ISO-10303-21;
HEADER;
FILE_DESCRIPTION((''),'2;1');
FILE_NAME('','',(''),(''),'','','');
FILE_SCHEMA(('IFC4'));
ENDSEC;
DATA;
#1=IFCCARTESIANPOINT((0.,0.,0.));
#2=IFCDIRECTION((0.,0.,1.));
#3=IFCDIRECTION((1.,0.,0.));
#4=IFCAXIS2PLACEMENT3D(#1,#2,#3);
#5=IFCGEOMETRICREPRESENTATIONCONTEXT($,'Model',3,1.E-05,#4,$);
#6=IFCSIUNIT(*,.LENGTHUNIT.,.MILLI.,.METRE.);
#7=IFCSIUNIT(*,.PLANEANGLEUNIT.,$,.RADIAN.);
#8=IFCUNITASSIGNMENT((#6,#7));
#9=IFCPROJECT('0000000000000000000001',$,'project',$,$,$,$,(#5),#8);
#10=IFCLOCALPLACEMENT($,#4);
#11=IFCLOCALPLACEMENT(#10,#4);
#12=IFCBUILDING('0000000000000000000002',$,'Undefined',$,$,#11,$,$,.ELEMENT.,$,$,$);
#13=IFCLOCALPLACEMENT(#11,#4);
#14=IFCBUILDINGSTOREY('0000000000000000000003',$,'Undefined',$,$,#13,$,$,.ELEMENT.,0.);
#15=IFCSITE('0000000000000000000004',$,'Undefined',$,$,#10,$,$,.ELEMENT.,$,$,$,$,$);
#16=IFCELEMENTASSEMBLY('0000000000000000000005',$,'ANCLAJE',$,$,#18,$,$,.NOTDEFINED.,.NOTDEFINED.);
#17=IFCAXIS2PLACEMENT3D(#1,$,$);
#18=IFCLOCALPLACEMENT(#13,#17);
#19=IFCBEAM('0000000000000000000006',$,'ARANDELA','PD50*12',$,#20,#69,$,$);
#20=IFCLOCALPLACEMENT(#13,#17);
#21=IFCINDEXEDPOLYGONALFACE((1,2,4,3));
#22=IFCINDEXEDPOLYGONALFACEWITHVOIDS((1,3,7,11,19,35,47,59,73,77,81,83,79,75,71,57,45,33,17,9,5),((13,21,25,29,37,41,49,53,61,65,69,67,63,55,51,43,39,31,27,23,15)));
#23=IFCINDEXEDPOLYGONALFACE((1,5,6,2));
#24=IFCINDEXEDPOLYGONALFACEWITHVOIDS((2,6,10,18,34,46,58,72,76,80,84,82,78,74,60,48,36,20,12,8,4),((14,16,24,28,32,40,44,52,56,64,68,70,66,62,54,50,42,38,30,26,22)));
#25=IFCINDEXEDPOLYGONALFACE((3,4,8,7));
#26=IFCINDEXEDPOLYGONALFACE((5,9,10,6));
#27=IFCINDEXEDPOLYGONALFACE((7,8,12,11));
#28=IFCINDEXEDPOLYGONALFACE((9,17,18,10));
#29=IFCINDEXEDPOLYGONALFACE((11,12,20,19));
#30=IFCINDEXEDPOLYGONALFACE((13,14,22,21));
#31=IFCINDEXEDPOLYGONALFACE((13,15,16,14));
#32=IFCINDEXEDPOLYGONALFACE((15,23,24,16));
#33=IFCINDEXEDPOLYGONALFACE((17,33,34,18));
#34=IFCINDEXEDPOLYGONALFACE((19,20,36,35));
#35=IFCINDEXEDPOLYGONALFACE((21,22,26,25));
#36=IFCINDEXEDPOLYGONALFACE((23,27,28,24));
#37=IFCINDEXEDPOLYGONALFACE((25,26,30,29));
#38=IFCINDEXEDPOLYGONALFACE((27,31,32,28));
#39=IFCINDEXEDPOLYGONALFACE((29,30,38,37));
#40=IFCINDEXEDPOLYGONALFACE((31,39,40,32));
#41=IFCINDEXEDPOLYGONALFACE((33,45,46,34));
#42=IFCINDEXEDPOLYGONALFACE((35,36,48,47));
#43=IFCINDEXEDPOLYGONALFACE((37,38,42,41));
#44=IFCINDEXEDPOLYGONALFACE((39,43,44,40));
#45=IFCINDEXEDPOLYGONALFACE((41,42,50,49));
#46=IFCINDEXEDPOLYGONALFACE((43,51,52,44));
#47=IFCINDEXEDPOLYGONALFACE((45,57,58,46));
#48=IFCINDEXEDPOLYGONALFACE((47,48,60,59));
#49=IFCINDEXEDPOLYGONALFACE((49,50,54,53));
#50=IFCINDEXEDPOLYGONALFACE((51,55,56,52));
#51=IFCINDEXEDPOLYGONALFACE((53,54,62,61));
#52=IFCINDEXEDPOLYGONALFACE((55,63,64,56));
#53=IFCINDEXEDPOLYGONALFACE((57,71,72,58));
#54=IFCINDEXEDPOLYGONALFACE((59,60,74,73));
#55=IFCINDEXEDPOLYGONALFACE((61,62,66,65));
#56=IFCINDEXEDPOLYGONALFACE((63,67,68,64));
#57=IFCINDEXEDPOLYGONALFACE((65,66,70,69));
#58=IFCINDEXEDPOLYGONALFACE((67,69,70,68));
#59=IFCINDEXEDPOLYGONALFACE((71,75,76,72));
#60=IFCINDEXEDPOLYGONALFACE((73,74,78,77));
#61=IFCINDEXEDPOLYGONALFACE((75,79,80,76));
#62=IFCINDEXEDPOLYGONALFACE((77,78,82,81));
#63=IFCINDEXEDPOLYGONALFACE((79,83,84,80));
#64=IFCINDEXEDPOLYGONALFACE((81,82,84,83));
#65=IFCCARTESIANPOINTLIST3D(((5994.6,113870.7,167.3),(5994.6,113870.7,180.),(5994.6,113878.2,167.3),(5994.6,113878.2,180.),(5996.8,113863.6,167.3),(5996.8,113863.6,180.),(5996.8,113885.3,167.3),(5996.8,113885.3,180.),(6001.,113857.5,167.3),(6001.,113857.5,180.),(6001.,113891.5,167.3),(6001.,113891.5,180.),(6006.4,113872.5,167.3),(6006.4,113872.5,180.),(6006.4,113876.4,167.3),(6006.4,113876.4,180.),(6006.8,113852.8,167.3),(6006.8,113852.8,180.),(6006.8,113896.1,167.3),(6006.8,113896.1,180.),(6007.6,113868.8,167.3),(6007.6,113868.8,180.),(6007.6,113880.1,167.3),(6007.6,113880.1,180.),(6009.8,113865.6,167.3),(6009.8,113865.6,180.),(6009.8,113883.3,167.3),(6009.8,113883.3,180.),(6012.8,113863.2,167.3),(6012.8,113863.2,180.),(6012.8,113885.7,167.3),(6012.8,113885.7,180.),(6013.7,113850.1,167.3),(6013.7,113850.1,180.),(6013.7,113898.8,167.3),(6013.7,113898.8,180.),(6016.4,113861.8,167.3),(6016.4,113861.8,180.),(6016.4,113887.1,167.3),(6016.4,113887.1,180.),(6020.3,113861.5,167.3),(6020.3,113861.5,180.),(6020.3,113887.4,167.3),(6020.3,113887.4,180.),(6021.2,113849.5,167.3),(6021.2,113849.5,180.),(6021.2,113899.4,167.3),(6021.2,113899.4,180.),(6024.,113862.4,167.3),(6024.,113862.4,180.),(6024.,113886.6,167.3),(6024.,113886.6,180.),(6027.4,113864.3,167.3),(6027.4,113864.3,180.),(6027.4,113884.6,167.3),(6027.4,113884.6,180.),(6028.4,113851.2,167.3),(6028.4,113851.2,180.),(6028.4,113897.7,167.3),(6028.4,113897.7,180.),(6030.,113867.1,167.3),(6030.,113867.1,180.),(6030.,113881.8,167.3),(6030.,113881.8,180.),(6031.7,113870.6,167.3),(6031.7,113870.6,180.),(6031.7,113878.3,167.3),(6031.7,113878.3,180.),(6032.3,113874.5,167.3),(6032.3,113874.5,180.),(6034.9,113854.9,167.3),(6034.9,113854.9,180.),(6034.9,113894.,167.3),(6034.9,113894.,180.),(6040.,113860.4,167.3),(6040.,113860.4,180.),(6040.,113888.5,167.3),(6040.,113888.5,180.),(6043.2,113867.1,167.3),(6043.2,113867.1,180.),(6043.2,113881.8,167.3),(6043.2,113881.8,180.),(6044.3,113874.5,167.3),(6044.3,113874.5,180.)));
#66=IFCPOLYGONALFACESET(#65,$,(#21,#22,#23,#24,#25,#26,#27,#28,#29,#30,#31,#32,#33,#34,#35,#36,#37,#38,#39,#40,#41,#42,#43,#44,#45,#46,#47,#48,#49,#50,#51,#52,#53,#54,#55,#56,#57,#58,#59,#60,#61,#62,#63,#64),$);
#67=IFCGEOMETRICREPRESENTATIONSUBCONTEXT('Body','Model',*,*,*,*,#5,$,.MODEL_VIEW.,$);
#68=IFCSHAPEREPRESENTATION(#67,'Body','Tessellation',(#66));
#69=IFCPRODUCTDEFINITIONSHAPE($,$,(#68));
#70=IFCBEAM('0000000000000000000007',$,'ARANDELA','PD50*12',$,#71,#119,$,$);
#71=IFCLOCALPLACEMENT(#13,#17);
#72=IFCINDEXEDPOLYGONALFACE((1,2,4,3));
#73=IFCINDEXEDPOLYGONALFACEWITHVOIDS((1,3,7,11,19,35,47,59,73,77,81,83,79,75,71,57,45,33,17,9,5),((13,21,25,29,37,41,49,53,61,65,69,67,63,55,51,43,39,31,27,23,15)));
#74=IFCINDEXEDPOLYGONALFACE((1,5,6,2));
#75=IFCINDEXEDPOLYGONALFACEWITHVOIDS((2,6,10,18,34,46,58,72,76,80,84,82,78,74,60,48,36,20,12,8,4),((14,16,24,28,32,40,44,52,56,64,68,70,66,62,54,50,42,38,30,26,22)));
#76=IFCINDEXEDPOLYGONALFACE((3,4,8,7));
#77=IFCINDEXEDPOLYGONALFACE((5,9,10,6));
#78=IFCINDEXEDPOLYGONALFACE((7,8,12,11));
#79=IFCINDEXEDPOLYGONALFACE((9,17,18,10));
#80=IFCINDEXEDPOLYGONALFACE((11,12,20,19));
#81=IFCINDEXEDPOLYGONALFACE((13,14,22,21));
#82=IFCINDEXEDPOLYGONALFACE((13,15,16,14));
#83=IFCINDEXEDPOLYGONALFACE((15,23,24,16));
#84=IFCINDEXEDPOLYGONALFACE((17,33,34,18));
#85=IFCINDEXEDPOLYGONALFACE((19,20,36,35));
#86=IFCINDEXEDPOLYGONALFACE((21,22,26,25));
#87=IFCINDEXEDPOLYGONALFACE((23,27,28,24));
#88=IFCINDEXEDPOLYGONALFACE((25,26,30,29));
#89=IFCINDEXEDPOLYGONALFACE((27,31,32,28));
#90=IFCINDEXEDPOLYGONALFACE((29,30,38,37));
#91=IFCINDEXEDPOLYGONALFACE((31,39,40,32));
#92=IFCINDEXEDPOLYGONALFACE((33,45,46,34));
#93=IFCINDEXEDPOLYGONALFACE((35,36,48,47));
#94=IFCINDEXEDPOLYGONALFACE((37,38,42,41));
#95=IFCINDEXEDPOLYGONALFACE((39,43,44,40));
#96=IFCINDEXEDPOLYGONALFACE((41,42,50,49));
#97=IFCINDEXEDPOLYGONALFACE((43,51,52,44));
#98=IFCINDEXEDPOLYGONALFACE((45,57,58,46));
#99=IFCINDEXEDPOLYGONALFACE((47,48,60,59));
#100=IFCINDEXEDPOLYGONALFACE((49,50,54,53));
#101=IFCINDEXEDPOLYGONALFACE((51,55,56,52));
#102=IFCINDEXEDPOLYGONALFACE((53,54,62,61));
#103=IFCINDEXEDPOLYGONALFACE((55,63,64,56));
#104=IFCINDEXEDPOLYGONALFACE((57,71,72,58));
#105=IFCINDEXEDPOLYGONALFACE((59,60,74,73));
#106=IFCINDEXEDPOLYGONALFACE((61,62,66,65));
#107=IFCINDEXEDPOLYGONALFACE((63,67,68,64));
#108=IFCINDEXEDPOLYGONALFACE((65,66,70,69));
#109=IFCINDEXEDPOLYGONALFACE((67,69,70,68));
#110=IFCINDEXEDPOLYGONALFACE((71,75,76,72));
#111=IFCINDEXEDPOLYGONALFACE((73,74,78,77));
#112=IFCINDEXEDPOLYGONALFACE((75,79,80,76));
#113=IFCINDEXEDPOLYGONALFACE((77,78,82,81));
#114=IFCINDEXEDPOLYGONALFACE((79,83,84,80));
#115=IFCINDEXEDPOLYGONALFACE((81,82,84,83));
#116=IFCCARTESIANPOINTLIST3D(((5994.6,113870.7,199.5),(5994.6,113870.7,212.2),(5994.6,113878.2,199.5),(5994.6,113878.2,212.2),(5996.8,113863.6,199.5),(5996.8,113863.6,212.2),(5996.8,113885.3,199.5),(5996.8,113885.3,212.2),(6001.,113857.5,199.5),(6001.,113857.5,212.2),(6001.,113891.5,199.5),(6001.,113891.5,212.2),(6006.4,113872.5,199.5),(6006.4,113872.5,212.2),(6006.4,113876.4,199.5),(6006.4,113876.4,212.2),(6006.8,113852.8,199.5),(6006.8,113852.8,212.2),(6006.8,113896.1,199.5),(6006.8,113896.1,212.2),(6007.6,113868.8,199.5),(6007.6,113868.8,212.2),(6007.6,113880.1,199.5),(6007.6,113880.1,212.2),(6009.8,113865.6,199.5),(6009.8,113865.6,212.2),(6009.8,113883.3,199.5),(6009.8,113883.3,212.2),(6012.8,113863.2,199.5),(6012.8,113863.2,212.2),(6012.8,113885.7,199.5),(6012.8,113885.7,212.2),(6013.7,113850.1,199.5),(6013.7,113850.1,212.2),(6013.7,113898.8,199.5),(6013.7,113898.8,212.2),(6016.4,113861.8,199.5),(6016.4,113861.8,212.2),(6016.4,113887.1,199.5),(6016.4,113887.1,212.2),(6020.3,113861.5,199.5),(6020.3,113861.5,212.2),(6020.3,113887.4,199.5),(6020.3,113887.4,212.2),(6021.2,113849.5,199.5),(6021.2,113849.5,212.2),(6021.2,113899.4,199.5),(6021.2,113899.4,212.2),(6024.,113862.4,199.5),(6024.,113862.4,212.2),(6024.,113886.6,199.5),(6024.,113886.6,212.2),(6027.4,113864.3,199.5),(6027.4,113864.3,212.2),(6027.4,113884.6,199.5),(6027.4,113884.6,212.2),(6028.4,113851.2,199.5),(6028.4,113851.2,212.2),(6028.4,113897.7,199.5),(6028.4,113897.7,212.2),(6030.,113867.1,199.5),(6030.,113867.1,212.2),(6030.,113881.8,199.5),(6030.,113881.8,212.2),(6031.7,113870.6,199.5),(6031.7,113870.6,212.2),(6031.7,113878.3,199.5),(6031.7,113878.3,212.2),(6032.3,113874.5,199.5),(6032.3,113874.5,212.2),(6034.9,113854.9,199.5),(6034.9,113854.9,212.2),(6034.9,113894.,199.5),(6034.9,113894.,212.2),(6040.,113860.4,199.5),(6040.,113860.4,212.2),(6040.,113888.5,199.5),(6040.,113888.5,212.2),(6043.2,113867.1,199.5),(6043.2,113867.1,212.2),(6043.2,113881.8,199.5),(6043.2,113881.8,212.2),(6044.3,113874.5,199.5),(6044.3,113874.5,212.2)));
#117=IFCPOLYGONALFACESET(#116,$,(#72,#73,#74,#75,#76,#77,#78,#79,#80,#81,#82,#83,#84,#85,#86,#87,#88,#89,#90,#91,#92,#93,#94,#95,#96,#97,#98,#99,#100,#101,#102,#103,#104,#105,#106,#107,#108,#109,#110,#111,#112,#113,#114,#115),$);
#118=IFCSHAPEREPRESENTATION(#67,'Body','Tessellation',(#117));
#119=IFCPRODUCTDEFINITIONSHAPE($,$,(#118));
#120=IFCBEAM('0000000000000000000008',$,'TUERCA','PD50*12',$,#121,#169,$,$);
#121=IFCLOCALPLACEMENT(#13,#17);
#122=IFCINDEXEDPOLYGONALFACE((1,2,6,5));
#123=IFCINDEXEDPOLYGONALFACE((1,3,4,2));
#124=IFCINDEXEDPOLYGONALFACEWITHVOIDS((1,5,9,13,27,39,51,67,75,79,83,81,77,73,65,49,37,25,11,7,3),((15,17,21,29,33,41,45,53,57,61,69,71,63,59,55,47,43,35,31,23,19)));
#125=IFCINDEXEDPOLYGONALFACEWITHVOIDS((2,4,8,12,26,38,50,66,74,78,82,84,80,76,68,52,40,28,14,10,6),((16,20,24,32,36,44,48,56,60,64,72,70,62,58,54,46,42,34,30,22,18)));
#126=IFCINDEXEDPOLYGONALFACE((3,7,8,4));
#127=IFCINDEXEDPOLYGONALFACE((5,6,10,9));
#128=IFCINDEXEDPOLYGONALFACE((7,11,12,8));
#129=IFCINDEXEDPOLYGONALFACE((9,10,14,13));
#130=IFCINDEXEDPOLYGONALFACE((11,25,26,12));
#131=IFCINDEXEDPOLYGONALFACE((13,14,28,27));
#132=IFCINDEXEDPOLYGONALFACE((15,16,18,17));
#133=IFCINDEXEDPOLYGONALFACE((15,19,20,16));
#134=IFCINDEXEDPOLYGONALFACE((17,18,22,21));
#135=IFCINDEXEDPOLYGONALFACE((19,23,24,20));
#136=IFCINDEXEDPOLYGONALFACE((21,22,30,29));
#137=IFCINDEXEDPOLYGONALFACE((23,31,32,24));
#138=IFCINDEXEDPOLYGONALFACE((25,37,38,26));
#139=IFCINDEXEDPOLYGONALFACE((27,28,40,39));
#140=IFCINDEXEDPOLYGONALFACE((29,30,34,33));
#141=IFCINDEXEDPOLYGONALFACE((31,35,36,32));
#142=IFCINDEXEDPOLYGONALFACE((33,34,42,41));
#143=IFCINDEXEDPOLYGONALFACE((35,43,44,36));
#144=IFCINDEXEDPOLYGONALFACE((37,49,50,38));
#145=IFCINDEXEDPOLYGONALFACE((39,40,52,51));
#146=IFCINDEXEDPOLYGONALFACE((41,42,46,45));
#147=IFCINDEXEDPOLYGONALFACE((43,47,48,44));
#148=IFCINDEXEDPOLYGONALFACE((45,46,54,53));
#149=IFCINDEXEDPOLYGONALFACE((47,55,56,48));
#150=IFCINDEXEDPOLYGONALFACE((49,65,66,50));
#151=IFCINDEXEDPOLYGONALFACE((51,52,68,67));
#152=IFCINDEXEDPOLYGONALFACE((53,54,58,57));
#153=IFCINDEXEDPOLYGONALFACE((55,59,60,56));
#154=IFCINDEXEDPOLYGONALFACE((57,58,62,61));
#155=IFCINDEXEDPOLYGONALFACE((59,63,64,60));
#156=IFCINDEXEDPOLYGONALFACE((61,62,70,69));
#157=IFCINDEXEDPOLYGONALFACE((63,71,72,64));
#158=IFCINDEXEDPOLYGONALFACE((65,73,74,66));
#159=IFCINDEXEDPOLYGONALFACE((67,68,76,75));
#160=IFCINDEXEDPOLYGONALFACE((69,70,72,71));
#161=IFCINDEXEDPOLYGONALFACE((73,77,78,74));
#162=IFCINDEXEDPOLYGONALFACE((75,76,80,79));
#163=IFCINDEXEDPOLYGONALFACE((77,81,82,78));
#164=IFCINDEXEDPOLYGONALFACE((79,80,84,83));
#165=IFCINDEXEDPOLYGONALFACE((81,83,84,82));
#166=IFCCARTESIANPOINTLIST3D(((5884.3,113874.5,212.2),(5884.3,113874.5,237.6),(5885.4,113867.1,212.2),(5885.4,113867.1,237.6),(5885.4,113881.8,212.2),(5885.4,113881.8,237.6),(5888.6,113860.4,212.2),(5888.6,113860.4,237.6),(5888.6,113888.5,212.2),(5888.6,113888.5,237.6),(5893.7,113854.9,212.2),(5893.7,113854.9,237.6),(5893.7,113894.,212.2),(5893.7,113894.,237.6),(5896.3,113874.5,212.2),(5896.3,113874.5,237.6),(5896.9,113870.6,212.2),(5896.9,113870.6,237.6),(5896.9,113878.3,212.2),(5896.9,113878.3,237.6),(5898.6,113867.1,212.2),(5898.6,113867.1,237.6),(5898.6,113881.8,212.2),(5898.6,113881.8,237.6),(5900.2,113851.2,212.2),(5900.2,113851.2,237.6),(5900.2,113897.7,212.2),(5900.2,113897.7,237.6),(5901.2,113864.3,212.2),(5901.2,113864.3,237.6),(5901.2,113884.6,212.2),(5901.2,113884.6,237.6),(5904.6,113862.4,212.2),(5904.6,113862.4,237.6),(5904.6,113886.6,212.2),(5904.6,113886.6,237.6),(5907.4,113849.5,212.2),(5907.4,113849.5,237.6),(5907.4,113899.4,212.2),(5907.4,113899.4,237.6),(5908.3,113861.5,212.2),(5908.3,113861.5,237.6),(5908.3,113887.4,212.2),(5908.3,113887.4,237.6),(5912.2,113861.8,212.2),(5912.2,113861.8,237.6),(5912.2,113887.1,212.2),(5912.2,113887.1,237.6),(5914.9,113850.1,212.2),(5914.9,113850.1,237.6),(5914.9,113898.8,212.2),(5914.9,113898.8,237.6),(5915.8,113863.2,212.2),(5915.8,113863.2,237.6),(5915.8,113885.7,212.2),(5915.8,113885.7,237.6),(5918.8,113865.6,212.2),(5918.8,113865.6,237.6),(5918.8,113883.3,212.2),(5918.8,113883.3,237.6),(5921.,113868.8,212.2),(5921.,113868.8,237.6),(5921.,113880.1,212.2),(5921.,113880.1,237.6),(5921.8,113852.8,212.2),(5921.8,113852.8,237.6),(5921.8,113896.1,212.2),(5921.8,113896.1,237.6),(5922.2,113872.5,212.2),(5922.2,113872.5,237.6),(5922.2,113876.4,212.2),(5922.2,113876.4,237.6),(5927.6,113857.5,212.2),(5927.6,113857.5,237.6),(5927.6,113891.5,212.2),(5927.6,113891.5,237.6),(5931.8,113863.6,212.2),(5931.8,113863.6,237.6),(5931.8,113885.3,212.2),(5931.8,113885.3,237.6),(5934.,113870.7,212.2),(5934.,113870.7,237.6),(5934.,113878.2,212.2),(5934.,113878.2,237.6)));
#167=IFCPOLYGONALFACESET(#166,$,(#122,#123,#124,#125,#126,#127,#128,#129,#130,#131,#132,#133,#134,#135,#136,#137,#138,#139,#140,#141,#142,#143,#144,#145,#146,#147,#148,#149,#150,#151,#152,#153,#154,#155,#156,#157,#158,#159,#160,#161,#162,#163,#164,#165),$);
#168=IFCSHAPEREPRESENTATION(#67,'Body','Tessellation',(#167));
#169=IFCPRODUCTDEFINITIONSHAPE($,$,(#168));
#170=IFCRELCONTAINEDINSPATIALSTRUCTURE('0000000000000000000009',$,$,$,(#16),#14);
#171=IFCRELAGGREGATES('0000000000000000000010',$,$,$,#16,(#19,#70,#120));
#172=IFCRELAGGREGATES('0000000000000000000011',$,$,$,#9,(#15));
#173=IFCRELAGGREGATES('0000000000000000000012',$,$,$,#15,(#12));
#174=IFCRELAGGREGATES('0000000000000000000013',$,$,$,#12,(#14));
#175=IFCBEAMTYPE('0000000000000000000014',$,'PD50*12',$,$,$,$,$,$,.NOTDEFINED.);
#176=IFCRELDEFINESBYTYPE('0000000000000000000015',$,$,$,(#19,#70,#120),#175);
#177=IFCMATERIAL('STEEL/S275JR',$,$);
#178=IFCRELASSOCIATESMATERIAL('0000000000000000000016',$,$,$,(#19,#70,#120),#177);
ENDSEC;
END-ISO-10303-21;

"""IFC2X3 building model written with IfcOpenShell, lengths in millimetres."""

from ifc_helpers import new_model, si_unit, frame, origin_with_axes, origin_2d_with_axis, place, context, subcontext, project, spatial, hollow_circle, extrude, material, type_object, element, aggregate, save


model = new_model("IFC2X3")

# Units and contexts
model_context = context("Model", 3, precision=1e-05, world=origin_with_axes())
body_context = subcontext(model_context, "Body", "Model", "MODEL_VIEW")
ifc_project = project(units=[si_unit("LENGTHUNIT", "METRE", prefix="MILLI"), si_unit("PLANEANGLEUNIT", "RADIAN")], contexts=[model_context])

# Site, building, storey
site_placement = place(None, origin_with_axes())
site = spatial("IfcSite", under=ifc_project, at=site_placement, Name="Undefined", CompositionType="ELEMENT")
building_placement = place(site_placement, origin_with_axes())
building = spatial("IfcBuilding", under=site, at=building_placement, Name="Undefined", CompositionType="ELEMENT")
storey_placement = place(building_placement, origin_with_axes())
storey = spatial("IfcBuildingStorey", under=building, at=storey_placement, Name="Undefined", CompositionType="ELEMENT", Elevation=0.0)

# Element assembly, beams
assembly_1_placement = place(storey_placement, origin_with_axes())
assembly_1 = element("IfcElementAssembly", 1, at=assembly_1_placement, inside=storey, Name="ANCLAJE", AssemblyPlace="NOTDEFINED", PredefinedType="NOTDEFINED")
ifc_material_1 = material(Name="STEEL/S275JR")
beam_type_1 = type_object("IfcBeamType", Name="PD50*12", PredefinedType="NOTDEFINED")
beam_1_placement = place(assembly_1_placement, frame((6019.3, 113874.5, 180.0), z_axis=(0.0, 1.0, 0.0), x_axis=(0.0, 0.0, -1.0)))
beam_1 = element("IfcBeam", 2, at=beam_1_placement, type_object=beam_type_1, material=ifc_material_1, Name="ARANDELA", Description="PD50*12", context=body_context, shape_type="SweptSolid", body=[
    extrude(hollow_circle(Radius=25.0, WallThickness=12.0, at=origin_2d_with_axis()), frame((12.7, 0.0, 0.0), z_axis=(-1.0, 0.0, 0.0), x_axis=(0.0, -1.0, 0.0)), (0.0, 0.0, 1.0), 12.7),
])
beam_2_placement = place(assembly_1_placement, frame((6019.3, 113874.5, 212.2), z_axis=(0.0, 1.0, 0.0), x_axis=(0.0, 0.0, -1.0)))
beam_2 = element("IfcBeam", 3, at=beam_2_placement, type_object=beam_type_1, material=ifc_material_1, Name="ARANDELA", Description="PD50*12", context=body_context, shape_type="SweptSolid", body=[
    extrude(hollow_circle(Radius=25.0, WallThickness=12.0, at=origin_2d_with_axis()), frame((12.7, 0.0, 0.0), z_axis=(-1.0, 0.0, 0.0), x_axis=(0.0, -1.0, 0.0)), (0.0, 0.0, 1.0), 12.7),
])
beam_3_placement = place(assembly_1_placement, frame((5909.3, 113874.5, 237.6), z_axis=(0.0, -1.0, 0.0), x_axis=(0.0, 0.0, -1.0)))
beam_3 = element("IfcBeam", 4, at=beam_3_placement, type_object=beam_type_1, material=ifc_material_1, Name="TUERCA", Description="PD50*12", context=body_context, shape_type="SweptSolid", body=[
    extrude(hollow_circle(Radius=25.0, WallThickness=12.0, at=origin_2d_with_axis()), frame((25.4, 0.0, 0.0), z_axis=(-1.0, 0.0, 0.0), x_axis=(0.0, -1.0, 0.0)), (0.0, 0.0, 1.0), 25.4),
])

aggregate(assembly_1, [beam_1, beam_2, beam_3])

save(model, "model.ifc")
